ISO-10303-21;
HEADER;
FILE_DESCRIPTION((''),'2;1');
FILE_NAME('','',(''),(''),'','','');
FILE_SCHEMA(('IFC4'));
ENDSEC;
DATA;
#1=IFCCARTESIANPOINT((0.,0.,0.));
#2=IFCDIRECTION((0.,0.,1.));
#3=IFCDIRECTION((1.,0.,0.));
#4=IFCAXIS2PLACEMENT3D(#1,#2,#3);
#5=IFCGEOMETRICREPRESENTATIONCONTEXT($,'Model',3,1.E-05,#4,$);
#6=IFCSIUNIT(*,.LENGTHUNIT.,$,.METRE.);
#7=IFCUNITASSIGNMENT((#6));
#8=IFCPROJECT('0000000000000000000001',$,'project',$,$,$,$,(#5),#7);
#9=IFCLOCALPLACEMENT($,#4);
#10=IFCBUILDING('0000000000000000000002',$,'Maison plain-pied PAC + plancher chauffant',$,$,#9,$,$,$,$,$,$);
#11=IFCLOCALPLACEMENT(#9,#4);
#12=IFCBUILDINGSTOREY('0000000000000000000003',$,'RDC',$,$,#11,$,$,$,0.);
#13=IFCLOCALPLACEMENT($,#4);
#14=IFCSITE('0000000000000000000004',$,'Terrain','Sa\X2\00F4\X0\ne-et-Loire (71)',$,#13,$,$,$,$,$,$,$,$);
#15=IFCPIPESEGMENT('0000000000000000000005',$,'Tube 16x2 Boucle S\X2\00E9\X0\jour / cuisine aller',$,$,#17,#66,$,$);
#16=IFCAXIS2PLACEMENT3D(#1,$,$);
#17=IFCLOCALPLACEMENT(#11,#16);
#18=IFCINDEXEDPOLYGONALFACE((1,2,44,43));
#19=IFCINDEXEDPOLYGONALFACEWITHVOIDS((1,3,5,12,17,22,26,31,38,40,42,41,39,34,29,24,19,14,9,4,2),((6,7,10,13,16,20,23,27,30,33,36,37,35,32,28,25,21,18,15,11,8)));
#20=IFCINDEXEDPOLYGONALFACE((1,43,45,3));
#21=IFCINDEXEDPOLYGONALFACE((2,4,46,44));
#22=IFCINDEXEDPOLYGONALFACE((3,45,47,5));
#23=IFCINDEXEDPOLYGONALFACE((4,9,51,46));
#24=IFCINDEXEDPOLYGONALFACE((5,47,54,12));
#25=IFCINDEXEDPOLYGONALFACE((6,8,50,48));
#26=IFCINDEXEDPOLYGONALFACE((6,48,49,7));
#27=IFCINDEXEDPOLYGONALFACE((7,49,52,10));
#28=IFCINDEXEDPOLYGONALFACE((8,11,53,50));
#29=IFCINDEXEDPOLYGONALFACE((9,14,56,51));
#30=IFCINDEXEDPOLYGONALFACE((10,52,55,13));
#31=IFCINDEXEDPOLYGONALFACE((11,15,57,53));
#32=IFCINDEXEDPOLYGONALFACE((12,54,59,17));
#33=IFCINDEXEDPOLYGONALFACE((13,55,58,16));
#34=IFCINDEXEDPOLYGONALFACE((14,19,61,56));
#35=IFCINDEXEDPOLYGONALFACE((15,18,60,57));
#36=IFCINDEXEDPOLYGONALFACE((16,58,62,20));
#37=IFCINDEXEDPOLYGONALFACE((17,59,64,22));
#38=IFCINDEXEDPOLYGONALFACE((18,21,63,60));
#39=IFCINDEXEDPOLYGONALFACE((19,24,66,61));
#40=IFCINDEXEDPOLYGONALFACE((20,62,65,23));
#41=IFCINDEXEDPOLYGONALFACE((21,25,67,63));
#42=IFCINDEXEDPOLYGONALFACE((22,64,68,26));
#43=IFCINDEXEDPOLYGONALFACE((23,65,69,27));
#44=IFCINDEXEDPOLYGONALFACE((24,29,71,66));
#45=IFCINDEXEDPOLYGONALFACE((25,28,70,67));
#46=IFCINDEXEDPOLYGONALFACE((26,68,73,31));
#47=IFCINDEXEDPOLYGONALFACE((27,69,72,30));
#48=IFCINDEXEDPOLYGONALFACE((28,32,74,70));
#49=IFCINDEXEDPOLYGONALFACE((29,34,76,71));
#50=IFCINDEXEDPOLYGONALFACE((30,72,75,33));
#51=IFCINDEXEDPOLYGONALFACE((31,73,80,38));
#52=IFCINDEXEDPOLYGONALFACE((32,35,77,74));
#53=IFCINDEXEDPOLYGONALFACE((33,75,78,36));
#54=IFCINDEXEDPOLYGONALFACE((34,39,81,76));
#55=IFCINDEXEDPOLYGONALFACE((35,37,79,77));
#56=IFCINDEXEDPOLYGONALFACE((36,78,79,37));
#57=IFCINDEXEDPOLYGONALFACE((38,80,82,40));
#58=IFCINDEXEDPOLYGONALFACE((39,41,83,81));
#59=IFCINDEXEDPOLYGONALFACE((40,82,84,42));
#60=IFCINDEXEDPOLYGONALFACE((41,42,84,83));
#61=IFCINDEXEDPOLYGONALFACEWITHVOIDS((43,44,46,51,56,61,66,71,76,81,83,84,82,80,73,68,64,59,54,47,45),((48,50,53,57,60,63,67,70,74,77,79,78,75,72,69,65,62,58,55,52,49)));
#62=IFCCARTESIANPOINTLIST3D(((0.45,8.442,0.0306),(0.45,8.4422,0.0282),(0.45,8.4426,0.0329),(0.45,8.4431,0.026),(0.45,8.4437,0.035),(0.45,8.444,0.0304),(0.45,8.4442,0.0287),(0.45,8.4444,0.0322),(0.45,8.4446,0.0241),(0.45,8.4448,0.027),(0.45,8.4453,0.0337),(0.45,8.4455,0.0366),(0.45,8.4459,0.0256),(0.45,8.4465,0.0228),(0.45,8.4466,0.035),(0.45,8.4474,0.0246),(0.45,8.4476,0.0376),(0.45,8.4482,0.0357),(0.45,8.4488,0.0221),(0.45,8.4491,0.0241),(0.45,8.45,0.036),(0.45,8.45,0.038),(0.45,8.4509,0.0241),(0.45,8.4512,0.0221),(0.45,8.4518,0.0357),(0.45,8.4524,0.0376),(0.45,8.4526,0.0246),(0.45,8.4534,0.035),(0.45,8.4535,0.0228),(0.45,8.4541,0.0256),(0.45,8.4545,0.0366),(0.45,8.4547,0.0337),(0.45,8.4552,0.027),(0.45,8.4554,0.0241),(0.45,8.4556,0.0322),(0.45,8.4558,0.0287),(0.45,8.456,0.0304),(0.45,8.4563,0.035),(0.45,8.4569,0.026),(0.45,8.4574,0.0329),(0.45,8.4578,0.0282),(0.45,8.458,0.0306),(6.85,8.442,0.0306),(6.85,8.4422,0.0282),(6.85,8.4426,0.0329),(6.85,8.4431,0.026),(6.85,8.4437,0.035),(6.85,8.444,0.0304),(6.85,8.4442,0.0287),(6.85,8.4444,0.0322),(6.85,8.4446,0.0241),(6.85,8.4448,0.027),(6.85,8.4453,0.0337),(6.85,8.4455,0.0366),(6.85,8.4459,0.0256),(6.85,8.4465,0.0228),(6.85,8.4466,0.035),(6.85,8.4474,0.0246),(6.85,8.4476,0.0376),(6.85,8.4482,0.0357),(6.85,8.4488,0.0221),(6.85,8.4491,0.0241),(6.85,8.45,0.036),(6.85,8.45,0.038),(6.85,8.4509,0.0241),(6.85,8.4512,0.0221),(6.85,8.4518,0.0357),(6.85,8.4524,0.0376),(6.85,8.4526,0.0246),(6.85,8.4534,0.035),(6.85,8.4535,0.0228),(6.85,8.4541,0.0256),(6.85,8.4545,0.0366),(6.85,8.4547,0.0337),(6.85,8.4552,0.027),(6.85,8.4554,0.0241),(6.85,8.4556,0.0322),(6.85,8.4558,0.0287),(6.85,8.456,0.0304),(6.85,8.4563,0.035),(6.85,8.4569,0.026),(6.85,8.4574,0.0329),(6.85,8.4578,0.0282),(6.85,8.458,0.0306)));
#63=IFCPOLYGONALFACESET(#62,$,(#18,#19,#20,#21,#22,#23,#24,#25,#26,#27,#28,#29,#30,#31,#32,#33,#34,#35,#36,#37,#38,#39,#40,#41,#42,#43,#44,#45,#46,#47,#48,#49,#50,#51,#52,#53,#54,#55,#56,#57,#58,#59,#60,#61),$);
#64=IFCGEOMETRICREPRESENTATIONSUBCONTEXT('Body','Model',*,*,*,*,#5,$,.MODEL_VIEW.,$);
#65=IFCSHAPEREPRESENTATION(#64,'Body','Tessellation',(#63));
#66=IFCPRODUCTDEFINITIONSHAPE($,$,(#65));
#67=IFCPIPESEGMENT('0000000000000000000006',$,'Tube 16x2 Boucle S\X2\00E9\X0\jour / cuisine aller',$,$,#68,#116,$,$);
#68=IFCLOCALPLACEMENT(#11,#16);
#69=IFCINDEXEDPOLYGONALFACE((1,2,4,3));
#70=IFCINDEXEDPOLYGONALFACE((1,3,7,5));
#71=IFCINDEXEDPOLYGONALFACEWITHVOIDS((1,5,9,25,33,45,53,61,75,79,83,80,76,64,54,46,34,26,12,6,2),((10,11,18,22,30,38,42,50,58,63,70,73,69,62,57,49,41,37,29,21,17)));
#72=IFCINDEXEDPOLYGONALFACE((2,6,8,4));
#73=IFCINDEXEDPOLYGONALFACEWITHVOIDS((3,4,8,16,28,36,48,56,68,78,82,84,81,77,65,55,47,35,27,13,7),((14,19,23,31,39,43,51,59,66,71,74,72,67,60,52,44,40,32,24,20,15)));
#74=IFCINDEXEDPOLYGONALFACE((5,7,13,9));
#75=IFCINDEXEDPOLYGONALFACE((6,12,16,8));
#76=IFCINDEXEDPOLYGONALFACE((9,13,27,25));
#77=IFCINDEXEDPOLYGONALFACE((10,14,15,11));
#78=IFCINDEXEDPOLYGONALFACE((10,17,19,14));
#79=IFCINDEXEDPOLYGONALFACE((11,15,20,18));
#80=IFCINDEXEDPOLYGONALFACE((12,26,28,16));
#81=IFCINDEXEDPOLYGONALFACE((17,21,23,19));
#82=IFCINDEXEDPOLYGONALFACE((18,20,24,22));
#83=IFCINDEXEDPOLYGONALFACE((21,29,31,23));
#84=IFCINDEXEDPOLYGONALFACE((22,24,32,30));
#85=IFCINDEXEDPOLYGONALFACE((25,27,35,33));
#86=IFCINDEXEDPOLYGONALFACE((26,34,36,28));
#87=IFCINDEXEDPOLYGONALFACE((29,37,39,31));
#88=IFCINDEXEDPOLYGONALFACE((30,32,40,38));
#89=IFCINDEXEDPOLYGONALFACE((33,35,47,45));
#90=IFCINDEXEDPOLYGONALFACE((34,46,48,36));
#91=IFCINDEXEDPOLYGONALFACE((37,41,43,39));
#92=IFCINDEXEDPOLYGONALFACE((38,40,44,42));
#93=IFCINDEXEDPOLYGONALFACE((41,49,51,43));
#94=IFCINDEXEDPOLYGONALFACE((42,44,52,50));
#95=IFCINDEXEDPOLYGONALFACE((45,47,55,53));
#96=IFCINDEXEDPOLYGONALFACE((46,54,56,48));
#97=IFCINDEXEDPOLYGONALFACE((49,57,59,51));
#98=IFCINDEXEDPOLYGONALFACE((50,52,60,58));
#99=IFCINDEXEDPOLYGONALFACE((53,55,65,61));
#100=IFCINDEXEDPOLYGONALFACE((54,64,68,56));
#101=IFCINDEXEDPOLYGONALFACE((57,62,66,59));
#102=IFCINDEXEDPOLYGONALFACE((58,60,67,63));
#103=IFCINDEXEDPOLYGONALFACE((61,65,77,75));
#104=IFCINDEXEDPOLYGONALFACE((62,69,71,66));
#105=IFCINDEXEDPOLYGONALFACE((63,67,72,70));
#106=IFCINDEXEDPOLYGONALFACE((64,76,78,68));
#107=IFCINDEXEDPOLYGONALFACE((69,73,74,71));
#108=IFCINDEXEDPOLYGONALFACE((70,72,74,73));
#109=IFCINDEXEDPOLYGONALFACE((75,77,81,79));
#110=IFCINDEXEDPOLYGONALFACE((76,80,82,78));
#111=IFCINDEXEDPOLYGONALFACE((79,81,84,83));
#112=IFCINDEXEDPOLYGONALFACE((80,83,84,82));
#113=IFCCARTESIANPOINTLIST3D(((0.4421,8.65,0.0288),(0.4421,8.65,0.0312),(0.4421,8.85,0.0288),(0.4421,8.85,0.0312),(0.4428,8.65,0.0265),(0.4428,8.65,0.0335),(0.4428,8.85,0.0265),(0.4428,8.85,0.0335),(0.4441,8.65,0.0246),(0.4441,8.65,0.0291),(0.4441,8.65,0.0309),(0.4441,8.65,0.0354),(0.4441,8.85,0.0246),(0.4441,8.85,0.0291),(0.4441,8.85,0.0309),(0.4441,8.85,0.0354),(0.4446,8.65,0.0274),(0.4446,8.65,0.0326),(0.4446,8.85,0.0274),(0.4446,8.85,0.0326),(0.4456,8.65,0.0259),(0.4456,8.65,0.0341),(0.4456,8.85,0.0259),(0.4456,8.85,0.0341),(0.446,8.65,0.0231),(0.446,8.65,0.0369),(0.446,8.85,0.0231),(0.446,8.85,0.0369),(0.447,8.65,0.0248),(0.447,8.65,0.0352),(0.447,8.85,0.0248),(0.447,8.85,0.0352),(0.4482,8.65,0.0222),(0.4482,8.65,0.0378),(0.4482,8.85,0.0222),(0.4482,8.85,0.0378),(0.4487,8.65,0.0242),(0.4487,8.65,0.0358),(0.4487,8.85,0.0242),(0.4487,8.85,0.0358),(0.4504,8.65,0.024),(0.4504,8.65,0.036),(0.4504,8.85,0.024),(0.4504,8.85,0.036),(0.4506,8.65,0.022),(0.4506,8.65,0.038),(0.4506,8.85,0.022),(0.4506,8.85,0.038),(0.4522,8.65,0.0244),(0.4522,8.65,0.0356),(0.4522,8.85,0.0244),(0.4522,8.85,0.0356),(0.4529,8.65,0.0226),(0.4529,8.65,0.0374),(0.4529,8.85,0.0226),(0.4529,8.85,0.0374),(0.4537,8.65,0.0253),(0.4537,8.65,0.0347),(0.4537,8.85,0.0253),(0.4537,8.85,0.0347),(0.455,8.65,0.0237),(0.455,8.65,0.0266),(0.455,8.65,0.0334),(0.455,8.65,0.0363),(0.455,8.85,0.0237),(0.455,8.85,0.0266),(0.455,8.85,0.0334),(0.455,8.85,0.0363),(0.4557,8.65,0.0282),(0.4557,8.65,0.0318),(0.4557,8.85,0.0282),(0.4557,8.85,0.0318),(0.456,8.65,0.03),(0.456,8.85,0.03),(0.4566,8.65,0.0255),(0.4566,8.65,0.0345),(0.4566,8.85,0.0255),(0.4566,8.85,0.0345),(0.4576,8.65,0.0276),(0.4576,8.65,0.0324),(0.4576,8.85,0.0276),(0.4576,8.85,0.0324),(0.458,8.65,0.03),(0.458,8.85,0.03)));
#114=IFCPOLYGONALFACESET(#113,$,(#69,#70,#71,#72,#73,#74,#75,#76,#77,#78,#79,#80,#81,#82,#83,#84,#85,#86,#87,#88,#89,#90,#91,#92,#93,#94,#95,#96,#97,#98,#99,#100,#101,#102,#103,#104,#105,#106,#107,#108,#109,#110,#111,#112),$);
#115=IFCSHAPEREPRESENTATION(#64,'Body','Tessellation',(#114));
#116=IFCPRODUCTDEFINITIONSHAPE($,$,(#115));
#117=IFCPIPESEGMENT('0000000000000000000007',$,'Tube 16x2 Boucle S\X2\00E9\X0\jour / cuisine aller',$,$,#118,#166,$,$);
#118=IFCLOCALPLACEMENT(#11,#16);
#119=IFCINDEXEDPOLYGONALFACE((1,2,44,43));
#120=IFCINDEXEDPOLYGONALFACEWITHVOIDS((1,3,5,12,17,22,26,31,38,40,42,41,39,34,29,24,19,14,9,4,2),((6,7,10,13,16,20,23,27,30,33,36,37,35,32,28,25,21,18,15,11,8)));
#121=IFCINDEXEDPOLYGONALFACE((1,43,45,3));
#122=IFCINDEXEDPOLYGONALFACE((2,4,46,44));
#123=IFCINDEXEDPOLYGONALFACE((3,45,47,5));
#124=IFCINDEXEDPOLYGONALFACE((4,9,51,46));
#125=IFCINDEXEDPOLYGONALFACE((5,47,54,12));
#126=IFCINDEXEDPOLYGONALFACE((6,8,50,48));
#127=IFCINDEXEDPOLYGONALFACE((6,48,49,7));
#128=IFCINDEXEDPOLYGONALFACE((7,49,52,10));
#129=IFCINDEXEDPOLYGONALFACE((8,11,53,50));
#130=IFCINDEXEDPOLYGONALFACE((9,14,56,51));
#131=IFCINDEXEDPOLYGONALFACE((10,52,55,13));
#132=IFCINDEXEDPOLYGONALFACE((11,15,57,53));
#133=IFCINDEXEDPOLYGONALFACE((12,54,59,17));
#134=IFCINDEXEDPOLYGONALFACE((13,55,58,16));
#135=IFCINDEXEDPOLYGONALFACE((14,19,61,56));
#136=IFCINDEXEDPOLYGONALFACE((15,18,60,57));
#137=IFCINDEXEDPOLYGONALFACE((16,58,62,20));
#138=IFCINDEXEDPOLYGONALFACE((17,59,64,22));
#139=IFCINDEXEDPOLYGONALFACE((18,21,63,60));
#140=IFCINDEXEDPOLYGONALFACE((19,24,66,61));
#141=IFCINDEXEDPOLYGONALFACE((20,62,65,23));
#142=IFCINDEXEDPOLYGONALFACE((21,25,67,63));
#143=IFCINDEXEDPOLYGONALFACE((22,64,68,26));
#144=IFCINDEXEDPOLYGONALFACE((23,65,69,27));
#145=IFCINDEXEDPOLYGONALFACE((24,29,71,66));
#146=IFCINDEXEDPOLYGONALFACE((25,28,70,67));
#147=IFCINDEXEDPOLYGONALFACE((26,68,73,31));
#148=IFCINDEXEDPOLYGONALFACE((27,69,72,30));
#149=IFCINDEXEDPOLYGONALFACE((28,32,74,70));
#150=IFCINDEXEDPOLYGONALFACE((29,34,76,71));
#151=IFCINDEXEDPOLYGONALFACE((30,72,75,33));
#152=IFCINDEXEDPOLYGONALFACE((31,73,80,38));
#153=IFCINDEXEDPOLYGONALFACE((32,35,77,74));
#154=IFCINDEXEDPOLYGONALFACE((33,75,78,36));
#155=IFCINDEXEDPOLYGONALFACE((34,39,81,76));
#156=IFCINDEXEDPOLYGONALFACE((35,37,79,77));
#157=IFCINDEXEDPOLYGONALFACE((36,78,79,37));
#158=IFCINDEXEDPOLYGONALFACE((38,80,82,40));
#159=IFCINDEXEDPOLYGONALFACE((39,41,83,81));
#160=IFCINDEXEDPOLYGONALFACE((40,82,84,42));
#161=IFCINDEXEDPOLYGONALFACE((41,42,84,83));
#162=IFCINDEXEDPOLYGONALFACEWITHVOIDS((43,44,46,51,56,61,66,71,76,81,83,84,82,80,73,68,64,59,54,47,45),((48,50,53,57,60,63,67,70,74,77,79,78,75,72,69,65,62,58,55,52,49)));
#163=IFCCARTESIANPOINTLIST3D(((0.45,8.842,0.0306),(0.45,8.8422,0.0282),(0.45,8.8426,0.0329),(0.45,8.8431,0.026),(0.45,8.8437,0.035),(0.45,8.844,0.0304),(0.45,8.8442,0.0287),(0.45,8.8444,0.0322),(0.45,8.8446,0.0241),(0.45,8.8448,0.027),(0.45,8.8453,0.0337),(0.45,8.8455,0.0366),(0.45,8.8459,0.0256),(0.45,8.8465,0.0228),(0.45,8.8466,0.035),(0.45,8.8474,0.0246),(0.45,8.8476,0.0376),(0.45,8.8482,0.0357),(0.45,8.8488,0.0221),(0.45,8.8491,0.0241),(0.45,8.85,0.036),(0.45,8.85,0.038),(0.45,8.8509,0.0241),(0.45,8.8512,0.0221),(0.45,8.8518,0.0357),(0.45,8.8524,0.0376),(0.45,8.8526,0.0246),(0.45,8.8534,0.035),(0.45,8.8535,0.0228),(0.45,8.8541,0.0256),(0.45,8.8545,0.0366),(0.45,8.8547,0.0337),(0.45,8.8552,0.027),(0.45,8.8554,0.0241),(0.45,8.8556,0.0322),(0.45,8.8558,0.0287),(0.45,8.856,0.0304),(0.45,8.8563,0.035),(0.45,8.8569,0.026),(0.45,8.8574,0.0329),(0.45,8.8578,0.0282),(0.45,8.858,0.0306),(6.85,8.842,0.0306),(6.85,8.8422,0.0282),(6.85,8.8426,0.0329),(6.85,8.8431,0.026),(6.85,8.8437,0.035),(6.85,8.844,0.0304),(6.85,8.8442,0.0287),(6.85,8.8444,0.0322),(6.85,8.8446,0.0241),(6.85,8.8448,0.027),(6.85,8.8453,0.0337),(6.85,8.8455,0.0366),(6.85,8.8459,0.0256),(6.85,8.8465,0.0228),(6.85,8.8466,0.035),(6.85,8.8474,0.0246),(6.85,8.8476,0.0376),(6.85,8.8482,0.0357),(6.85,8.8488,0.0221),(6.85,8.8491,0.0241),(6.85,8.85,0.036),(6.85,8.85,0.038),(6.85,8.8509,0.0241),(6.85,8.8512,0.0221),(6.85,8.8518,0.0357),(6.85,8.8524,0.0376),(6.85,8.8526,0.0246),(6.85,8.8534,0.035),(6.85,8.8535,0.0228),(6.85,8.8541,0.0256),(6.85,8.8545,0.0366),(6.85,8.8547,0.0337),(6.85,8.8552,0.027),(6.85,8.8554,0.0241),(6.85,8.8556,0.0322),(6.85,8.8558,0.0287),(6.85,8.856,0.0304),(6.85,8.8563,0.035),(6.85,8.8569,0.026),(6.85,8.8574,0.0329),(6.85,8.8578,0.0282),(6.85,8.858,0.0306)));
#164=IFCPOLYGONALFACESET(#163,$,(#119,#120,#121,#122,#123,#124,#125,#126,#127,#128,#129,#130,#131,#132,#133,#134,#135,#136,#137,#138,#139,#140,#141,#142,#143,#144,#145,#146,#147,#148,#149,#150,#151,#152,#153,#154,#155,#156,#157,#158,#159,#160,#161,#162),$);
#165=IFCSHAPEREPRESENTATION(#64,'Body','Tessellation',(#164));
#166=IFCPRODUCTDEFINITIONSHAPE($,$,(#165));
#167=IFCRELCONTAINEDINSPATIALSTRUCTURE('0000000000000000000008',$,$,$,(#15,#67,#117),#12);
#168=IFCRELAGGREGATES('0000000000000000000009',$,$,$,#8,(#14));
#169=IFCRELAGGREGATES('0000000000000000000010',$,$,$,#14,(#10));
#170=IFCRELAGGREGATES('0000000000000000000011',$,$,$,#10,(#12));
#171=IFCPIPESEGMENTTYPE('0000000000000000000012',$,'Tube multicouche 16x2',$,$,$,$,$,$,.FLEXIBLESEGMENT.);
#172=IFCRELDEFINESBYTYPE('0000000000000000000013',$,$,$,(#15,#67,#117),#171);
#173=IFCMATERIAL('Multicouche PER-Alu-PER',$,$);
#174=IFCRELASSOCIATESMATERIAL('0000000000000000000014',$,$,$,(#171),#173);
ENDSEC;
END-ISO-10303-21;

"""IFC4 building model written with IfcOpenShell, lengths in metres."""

from ifc_helpers import new_model, si_unit, frame, origin_with_axes, place, context, subcontext, project, spatial, hollow_circle, extrude, material, type_object, element, save


model = new_model("IFC4")

# Units and contexts
model_context = context("Model", 3, precision=1e-05, world=origin_with_axes())
body_context = subcontext(model_context, "Body", "Model", "MODEL_VIEW")
ifc_project = project(units=[si_unit("LENGTHUNIT", "METRE")], contexts=[model_context])

# Site, building, storey
site_placement = place(None, origin_with_axes())
site = spatial("IfcSite", under=ifc_project, at=site_placement, Name="Terrain", Description="Saône-et-Loire (71)")
building_placement = place(None, origin_with_axes())
building = spatial("IfcBuilding", under=site, at=building_placement, Name="Maison plain-pied PAC + plancher chauffant")
storey_placement = place(building_placement, origin_with_axes())
storey = spatial("IfcBuildingStorey", under=building, at=storey_placement, Name="RDC", Elevation=0.0)

# Pipe segments
ifc_material_1 = material(Name="Multicouche PER-Alu-PER")
pipe_segment_type_1 = type_object("IfcPipeSegmentType", Name="Tube multicouche 16x2", PredefinedType="FLEXIBLESEGMENT", material=ifc_material_1)
pipe_segment_1_placement = place(storey_placement, frame((0.45, 8.45, 0.03), z_axis=(1.0, 0.0, 0.0), x_axis=(0.0, 0.0, 1.0)))
element("IfcPipeSegment", 1, at=pipe_segment_1_placement, inside=storey, type_object=pipe_segment_type_1, Name="Tube 16x2 Boucle Séjour / cuisine aller", context=body_context, shape_type="SweptSolid", body=[
    extrude(hollow_circle(Radius=0.008, WallThickness=0.002), origin_with_axes(), (0.0, 0.0, 1.0), 6.4),
])
pipe_segment_2_placement = place(storey_placement, frame((0.45, 8.65, 0.03), z_axis=(0.0, 1.0, 0.0), x_axis=(1.0, 0.0, 0.0)))
element("IfcPipeSegment", 2, at=pipe_segment_2_placement, inside=storey, type_object=pipe_segment_type_1, Name="Tube 16x2 Boucle Séjour / cuisine aller", context=body_context, shape_type="SweptSolid", body=[
    extrude(hollow_circle(Radius=0.008, WallThickness=0.002), origin_with_axes(), (0.0, 0.0, 1.0), 0.2),
])
pipe_segment_3_placement = place(storey_placement, frame((0.45, 8.85, 0.03), z_axis=(1.0, 0.0, 0.0), x_axis=(0.0, 0.0, 1.0)))
element("IfcPipeSegment", 3, at=pipe_segment_3_placement, inside=storey, type_object=pipe_segment_type_1, Name="Tube 16x2 Boucle Séjour / cuisine aller", context=body_context, shape_type="SweptSolid", body=[
    extrude(hollow_circle(Radius=0.008, WallThickness=0.002), origin_with_axes(), (0.0, 0.0, 1.0), 6.4),
])

save(model, "model.ifc")
